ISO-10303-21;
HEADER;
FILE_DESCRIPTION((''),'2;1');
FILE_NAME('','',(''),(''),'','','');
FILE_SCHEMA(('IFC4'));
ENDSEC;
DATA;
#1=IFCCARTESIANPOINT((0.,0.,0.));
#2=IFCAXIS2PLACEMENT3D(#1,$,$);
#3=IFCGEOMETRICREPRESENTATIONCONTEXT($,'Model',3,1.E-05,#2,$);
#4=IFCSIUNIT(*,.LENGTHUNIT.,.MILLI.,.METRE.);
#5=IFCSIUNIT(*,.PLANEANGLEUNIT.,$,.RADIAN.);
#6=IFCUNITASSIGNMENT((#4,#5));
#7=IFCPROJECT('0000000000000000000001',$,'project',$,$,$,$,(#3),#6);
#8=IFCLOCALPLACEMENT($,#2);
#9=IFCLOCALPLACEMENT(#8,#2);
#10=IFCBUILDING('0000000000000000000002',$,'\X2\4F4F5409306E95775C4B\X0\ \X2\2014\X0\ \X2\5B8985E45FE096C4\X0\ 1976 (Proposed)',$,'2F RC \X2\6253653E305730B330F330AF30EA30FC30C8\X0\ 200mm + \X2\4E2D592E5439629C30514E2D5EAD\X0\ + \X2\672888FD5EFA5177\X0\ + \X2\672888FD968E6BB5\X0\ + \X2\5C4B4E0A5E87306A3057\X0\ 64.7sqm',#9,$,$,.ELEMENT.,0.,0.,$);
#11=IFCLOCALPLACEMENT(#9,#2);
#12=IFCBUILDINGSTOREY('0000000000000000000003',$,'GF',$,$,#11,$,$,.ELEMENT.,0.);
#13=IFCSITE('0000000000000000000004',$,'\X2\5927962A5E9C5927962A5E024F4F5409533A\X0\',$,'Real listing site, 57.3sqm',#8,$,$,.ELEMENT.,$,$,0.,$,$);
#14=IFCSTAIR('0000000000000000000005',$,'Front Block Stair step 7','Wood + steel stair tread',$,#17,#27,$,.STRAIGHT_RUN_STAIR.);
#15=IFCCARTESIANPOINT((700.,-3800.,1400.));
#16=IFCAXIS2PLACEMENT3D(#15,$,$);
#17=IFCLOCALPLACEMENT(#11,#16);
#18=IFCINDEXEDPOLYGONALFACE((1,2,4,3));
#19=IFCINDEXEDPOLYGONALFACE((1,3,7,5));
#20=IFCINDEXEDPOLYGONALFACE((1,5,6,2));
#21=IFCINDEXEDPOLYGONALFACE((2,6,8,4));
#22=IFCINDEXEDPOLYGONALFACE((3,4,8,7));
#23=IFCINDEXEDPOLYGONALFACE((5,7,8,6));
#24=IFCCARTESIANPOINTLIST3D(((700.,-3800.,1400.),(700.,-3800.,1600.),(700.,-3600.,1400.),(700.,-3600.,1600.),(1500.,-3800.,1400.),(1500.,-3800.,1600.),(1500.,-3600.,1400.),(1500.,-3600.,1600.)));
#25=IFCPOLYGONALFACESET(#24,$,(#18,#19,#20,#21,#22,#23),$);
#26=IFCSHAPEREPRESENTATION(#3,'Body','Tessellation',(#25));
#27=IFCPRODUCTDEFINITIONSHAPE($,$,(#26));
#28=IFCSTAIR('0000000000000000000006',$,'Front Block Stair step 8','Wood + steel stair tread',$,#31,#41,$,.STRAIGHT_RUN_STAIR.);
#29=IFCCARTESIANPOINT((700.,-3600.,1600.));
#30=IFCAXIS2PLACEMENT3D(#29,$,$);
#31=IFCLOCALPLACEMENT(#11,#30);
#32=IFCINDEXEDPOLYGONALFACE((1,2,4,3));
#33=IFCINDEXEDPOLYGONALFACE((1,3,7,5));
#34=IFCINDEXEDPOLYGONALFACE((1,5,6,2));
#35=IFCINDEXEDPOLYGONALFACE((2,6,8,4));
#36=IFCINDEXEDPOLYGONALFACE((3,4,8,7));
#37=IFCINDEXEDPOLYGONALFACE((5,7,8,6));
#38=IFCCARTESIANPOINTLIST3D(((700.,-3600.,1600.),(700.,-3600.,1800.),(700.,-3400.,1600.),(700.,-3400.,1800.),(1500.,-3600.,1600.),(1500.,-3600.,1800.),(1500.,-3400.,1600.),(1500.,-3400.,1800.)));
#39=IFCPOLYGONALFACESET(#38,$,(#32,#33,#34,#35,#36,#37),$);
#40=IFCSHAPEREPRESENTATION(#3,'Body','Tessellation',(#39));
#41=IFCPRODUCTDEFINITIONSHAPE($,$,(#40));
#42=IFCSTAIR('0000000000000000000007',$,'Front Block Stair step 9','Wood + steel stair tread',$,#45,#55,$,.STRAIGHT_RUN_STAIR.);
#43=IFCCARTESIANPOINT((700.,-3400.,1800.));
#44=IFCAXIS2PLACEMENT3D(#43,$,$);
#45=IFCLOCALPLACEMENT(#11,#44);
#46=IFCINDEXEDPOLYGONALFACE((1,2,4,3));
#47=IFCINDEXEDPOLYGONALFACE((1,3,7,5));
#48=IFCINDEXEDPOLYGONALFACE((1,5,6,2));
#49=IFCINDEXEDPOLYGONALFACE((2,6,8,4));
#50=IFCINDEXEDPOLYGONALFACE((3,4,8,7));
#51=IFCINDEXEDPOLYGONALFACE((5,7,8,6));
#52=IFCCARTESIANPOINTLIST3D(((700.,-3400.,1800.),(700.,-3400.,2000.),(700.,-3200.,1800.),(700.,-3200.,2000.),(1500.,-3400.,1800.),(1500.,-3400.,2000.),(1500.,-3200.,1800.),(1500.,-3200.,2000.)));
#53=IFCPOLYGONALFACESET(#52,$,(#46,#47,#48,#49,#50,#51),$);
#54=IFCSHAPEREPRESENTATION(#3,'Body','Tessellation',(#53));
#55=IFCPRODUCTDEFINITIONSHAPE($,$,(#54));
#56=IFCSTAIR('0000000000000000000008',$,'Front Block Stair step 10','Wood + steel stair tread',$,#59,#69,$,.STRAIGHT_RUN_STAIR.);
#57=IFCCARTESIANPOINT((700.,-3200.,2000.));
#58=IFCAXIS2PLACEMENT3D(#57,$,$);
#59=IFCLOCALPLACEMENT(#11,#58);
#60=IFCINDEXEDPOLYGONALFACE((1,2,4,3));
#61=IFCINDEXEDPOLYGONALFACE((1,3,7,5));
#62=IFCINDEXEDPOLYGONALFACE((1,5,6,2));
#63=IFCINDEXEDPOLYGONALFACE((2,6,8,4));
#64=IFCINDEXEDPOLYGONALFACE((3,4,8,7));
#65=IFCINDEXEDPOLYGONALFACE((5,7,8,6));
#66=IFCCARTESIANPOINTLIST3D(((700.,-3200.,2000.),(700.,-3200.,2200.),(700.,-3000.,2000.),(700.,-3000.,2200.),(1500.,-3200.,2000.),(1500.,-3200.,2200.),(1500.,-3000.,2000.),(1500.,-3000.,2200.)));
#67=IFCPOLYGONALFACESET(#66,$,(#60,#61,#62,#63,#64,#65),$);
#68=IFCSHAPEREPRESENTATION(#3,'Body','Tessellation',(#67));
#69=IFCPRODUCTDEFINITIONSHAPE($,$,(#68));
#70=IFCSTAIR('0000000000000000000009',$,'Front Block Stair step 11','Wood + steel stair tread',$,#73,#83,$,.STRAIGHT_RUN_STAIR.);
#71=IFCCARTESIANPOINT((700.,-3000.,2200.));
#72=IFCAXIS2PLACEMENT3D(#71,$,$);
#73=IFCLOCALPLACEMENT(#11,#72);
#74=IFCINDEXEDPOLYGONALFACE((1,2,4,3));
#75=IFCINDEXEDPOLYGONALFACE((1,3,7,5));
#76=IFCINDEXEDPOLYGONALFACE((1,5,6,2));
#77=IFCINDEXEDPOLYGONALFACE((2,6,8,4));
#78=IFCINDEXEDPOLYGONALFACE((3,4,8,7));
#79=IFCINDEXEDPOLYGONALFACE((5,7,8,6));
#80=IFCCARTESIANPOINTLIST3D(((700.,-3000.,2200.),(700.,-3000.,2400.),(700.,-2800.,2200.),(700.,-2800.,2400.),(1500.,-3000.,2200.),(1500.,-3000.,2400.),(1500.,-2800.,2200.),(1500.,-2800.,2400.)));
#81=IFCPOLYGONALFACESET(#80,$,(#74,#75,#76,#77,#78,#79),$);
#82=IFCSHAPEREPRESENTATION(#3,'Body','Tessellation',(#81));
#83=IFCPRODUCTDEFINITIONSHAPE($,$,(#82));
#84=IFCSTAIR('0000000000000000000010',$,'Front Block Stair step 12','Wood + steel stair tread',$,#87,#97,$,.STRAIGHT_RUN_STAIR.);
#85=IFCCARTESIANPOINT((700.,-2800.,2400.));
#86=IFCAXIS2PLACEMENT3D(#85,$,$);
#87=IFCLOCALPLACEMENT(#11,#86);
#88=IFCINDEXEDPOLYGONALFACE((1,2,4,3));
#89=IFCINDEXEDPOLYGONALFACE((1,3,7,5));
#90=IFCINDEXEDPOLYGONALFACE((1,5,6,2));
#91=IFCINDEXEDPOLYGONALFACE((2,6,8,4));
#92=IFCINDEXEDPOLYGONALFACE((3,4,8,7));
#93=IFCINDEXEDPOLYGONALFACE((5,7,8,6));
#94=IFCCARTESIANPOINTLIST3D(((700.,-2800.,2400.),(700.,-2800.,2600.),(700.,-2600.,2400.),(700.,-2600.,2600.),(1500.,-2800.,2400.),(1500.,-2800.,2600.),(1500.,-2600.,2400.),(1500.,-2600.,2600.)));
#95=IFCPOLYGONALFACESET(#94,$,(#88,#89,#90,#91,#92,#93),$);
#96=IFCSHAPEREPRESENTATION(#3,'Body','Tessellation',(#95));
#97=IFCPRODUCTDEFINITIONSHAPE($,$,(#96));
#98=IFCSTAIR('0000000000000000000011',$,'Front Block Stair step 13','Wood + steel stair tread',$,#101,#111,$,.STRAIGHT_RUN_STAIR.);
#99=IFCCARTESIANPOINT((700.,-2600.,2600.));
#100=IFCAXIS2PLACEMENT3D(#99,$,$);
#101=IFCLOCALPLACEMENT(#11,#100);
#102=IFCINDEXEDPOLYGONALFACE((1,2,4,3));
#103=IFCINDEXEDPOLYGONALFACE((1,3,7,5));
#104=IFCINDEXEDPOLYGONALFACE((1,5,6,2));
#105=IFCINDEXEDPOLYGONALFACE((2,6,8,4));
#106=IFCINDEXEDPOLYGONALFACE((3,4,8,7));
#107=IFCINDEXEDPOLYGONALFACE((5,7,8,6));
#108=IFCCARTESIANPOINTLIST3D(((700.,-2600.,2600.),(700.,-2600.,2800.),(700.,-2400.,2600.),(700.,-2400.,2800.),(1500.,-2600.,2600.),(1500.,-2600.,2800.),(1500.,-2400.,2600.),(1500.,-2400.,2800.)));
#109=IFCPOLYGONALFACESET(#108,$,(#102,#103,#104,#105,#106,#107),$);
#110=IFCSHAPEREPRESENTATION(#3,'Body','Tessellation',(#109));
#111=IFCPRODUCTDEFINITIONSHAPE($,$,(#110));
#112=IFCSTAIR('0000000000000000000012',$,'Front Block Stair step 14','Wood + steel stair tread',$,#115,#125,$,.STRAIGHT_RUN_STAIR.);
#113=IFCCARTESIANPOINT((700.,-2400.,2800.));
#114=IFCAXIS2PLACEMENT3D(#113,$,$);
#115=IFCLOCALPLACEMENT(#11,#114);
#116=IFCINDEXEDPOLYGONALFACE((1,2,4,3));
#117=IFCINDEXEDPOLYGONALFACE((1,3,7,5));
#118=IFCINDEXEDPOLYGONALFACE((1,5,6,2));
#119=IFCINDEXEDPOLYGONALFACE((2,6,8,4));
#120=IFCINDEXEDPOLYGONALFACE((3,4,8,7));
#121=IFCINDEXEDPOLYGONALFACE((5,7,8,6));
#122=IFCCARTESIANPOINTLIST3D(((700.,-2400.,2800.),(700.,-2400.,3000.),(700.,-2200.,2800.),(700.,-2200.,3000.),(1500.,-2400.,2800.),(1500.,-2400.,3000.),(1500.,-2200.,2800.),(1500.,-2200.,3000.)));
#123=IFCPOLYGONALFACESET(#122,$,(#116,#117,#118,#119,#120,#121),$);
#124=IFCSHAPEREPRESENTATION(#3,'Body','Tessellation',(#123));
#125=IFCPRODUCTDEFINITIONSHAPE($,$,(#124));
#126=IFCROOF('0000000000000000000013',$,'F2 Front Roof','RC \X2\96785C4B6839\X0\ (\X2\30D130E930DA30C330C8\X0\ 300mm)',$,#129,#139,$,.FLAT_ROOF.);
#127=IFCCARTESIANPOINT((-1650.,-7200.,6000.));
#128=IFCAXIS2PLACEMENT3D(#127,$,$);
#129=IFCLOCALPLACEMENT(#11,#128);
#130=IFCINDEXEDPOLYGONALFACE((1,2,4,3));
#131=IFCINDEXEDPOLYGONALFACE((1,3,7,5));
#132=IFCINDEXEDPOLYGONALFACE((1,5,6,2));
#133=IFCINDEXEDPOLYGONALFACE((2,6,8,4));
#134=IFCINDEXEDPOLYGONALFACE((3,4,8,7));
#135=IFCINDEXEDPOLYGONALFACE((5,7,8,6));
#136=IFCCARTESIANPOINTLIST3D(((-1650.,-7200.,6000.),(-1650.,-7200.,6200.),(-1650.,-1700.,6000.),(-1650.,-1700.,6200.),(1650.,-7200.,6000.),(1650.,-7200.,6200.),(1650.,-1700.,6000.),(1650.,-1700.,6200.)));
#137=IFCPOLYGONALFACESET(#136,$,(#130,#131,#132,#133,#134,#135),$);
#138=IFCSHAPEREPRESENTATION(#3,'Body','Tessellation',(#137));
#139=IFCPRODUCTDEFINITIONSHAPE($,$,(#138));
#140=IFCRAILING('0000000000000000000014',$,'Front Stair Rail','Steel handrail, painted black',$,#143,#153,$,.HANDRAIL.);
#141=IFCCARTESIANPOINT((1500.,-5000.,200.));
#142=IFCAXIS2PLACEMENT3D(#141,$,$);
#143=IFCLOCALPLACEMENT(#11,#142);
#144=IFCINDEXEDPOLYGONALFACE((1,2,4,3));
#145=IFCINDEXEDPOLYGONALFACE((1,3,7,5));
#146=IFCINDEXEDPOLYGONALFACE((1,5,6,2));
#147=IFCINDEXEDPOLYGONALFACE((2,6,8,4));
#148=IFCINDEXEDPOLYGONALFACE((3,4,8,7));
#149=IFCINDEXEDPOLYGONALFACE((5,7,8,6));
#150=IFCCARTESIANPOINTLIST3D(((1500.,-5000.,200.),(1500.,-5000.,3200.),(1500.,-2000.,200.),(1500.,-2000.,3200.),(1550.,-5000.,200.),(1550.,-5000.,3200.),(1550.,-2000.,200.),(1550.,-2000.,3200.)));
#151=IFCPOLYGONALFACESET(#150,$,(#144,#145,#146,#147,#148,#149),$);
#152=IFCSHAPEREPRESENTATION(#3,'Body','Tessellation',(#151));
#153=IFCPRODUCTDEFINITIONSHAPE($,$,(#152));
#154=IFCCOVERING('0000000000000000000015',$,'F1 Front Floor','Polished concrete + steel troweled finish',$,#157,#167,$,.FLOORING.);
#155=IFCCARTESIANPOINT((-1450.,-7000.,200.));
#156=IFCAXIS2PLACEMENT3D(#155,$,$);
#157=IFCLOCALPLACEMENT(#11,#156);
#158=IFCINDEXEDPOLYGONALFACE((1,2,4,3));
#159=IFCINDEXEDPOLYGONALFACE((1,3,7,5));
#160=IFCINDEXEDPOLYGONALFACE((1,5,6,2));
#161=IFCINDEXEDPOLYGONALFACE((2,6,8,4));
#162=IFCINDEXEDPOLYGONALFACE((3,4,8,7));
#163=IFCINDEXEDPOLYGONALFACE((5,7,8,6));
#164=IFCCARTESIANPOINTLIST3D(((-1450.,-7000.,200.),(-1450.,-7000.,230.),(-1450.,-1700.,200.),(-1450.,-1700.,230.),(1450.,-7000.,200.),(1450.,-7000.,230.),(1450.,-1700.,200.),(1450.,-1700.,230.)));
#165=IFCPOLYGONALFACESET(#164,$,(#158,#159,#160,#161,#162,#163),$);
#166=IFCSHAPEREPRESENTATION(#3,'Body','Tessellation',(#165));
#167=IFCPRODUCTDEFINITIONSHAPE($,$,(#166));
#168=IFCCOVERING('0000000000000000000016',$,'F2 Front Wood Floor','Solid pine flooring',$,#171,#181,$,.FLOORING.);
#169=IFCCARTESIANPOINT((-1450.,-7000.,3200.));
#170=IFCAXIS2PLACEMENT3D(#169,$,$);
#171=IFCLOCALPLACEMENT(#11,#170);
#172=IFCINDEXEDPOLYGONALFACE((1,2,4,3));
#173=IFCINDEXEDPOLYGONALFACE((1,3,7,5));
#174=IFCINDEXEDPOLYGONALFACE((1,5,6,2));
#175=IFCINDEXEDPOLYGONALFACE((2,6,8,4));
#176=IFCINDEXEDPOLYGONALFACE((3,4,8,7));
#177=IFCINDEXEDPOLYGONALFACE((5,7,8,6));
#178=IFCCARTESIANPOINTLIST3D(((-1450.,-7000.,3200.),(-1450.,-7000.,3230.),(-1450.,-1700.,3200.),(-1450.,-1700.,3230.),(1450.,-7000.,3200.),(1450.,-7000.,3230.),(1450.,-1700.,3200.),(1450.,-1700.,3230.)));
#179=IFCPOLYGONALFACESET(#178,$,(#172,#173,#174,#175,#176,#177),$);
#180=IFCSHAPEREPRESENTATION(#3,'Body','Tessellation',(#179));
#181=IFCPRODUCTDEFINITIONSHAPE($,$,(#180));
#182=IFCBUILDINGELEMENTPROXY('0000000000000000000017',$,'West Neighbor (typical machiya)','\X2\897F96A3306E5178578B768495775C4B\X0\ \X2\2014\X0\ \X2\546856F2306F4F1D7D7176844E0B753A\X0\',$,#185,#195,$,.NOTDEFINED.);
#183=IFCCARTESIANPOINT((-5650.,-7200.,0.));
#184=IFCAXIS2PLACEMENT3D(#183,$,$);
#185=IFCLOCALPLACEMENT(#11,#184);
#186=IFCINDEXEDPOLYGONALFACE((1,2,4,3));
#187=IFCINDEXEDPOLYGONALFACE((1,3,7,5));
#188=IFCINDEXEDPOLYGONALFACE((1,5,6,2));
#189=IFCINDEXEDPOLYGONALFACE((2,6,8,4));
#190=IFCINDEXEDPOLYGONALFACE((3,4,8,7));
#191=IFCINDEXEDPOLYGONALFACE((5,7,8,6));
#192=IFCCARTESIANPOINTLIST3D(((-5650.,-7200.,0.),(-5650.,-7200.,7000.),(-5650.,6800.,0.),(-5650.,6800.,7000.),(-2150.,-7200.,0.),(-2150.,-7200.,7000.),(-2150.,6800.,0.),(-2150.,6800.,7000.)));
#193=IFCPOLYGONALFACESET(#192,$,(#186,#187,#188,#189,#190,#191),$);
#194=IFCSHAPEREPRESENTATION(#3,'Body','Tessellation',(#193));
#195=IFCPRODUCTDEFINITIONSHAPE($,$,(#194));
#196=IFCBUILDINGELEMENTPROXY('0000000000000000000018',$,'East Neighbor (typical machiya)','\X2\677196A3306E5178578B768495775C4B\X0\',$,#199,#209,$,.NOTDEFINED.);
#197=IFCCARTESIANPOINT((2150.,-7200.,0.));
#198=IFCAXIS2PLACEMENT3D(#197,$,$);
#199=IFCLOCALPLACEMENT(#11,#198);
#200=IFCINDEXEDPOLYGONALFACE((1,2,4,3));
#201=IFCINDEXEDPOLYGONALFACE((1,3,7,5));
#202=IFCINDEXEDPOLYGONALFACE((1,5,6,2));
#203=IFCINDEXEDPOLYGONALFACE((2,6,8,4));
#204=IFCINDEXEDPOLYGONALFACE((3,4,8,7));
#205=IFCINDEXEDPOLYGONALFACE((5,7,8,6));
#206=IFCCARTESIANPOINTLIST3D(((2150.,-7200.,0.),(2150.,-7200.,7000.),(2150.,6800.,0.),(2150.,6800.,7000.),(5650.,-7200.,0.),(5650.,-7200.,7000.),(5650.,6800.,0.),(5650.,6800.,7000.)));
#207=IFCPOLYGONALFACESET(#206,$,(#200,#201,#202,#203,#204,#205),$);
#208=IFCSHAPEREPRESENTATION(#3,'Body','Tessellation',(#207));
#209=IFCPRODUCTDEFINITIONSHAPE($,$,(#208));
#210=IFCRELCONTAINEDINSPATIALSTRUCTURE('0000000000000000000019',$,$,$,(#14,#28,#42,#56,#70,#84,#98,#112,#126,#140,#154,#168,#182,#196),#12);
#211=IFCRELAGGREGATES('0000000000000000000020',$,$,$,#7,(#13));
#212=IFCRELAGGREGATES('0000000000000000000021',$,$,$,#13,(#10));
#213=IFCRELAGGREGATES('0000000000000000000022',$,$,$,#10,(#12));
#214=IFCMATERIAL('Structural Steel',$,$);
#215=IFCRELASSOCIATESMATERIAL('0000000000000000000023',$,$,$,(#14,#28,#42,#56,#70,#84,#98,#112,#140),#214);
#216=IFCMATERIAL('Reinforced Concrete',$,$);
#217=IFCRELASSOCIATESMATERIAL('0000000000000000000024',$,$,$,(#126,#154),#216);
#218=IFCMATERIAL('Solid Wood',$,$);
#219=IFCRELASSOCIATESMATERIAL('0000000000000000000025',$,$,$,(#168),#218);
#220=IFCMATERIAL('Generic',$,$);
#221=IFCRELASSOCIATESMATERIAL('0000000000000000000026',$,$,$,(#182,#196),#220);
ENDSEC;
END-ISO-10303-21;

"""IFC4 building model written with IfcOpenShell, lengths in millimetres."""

from ifc_helpers import new_model, si_unit, frame, frame_2d, origin, place, context, project, spatial, rectangle, extrude, material, element, save


model = new_model("IFC4")

# Units and contexts
model_context = context("Model", 3, precision=1e-05, world=origin())
ifc_project = project(units=[si_unit("LENGTHUNIT", "METRE", prefix="MILLI"), si_unit("PLANEANGLEUNIT", "RADIAN")], contexts=[model_context])

# Site, building, storey
site_placement = place(None, origin())
site = spatial("IfcSite", under=ifc_project, at=site_placement, Name="大阪府大阪市住吉区", ObjectType="Real listing site, 57.3sqm", CompositionType="ELEMENT", RefElevation=0.0)
building_placement = place(site_placement, origin())
building = spatial("IfcBuilding", under=site, at=building_placement, Name="住吉の長屋 — 安藤忠雄 1976 (Proposed)", ObjectType="2F RC 打放しコンクリート 200mm + 中央吹抜け中庭 + 木製建具 + 木製階段 + 屋上庇なし 64.7sqm", CompositionType="ELEMENT", ElevationOfRefHeight=0.0, ElevationOfTerrain=0.0)
storey_placement = place(building_placement, origin())
storey = spatial("IfcBuildingStorey", under=building, at=storey_placement, Name="GF", CompositionType="ELEMENT", Elevation=0.0)

# Shared definitions
ifc_material_1 = material(Name="Reinforced Concrete")
ifc_material_2 = material(Name="Generic")

# Shared definitions
ifc_material_3 = material(Name="Solid Wood")

# Stairs
ifc_material_4 = material(Name="Structural Steel")
stair_1_placement = place(storey_placement, frame((700.0, -3800.0, 1400.0)))
element("IfcStair", 1, at=stair_1_placement, inside=storey, material=ifc_material_4, Name="Front Block Stair step 7", Description="Wood + steel stair tread", PredefinedType="STRAIGHT_RUN_STAIR", context=model_context, shape_type="SweptSolid", body=[
    extrude(rectangle(XDim=800.0, YDim=200.0, at=frame_2d((400.0, 100.0))), frame((700.0, -3800.0, 1400.0)), (0.0, 0.0, 1.0), 200.0),
])
stair_2_placement = place(storey_placement, frame((700.0, -3600.0, 1600.0)))
element("IfcStair", 2, at=stair_2_placement, inside=storey, material=ifc_material_4, Name="Front Block Stair step 8", Description="Wood + steel stair tread", PredefinedType="STRAIGHT_RUN_STAIR", context=model_context, shape_type="SweptSolid", body=[
    extrude(rectangle(XDim=800.0, YDim=200.0, at=frame_2d((400.0, 100.0))), frame((700.0, -3600.0, 1600.0)), (0.0, 0.0, 1.0), 200.0),
])
stair_3_placement = place(storey_placement, frame((700.0, -3400.0, 1800.0)))
element("IfcStair", 3, at=stair_3_placement, inside=storey, material=ifc_material_4, Name="Front Block Stair step 9", Description="Wood + steel stair tread", PredefinedType="STRAIGHT_RUN_STAIR", context=model_context, shape_type="SweptSolid", body=[
    extrude(rectangle(XDim=800.0, YDim=200.0, at=frame_2d((400.0, 100.0))), frame((700.0, -3400.0, 1800.0)), (0.0, 0.0, 1.0), 200.0),
])
stair_4_placement = place(storey_placement, frame((700.0, -3200.0, 2000.0)))
element("IfcStair", 4, at=stair_4_placement, inside=storey, material=ifc_material_4, Name="Front Block Stair step 10", Description="Wood + steel stair tread", PredefinedType="STRAIGHT_RUN_STAIR", context=model_context, shape_type="SweptSolid", body=[
    extrude(rectangle(XDim=800.0, YDim=200.0, at=frame_2d((400.0, 100.0))), frame((700.0, -3200.0, 2000.0)), (0.0, 0.0, 1.0), 200.0),
])
stair_5_placement = place(storey_placement, frame((700.0, -3000.0, 2200.0)))
element("IfcStair", 5, at=stair_5_placement, inside=storey, material=ifc_material_4, Name="Front Block Stair step 11", Description="Wood + steel stair tread", PredefinedType="STRAIGHT_RUN_STAIR", context=model_context, shape_type="SweptSolid", body=[
    extrude(rectangle(XDim=800.0, YDim=200.0, at=frame_2d((400.0, 100.0))), frame((700.0, -3000.0, 2200.0)), (0.0, 0.0, 1.0), 200.0),
])
stair_6_placement = place(storey_placement, frame((700.0, -2800.0, 2400.0)))
element("IfcStair", 6, at=stair_6_placement, inside=storey, material=ifc_material_4, Name="Front Block Stair step 12", Description="Wood + steel stair tread", PredefinedType="STRAIGHT_RUN_STAIR", context=model_context, shape_type="SweptSolid", body=[
    extrude(rectangle(XDim=800.0, YDim=200.0, at=frame_2d((400.0, 100.0))), frame((700.0, -2800.0, 2400.0)), (0.0, 0.0, 1.0), 200.0),
])
stair_7_placement = place(storey_placement, frame((700.0, -2600.0, 2600.0)))
element("IfcStair", 7, at=stair_7_placement, inside=storey, material=ifc_material_4, Name="Front Block Stair step 13", Description="Wood + steel stair tread", PredefinedType="STRAIGHT_RUN_STAIR", context=model_context, shape_type="SweptSolid", body=[
    extrude(rectangle(XDim=800.0, YDim=200.0, at=frame_2d((400.0, 100.0))), frame((700.0, -2600.0, 2600.0)), (0.0, 0.0, 1.0), 200.0),
])
stair_8_placement = place(storey_placement, frame((700.0, -2400.0, 2800.0)))
element("IfcStair", 8, at=stair_8_placement, inside=storey, material=ifc_material_4, Name="Front Block Stair step 14", Description="Wood + steel stair tread", PredefinedType="STRAIGHT_RUN_STAIR", context=model_context, shape_type="SweptSolid", body=[
    extrude(rectangle(XDim=800.0, YDim=200.0, at=frame_2d((400.0, 100.0))), frame((700.0, -2400.0, 2800.0)), (0.0, 0.0, 1.0), 200.0),
])

# Roof
roof_placement = place(storey_placement, frame((-1650.0, -7200.0, 6000.0)))
element("IfcRoof", 9, at=roof_placement, inside=storey, material=ifc_material_1, Name="F2 Front Roof", Description="RC 陸屋根 (パラペット 300mm)", PredefinedType="FLAT_ROOF", context=model_context, shape_type="SweptSolid", body=[
    extrude(rectangle(XDim=3300.0, YDim=5500.0, at=frame_2d((1650.0, 2750.0))), frame((-1650.0, -7200.0, 6000.0)), (0.0, 0.0, 1.0), 200.0),
])

# Railing
railing_placement = place(storey_placement, frame((1500.0, -5000.0, 200.0)))
element("IfcRailing", 10, at=railing_placement, inside=storey, material=ifc_material_4, Name="Front Stair Rail", Description="Steel handrail, painted black", PredefinedType="HANDRAIL", context=model_context, shape_type="SweptSolid", body=[
    extrude(rectangle(XDim=50.0, YDim=3000.0, at=frame_2d((25.0, 1500.0))), frame((1500.0, -5000.0, 200.0)), (0.0, 0.0, 1.0), 3000.0),
])

# Coverings
covering_1_placement = place(storey_placement, frame((-1450.0, -7000.0, 200.0)))
element("IfcCovering", 11, at=covering_1_placement, inside=storey, material=ifc_material_1, Name="F1 Front Floor", Description="Polished concrete + steel troweled finish", PredefinedType="FLOORING", context=model_context, shape_type="SweptSolid", body=[
    extrude(rectangle(XDim=2900.0, YDim=5300.0, at=frame_2d((1450.0, 2650.0))), frame((-1450.0, -7000.0, 200.0)), (0.0, 0.0, 1.0), 30.0),
])
covering_2_placement = place(storey_placement, frame((-1450.0, -7000.0, 3200.0)))
element("IfcCovering", 12, at=covering_2_placement, inside=storey, material=ifc_material_3, Name="F2 Front Wood Floor", Description="Solid pine flooring", PredefinedType="FLOORING", context=model_context, shape_type="SweptSolid", body=[
    extrude(rectangle(XDim=2900.0, YDim=5300.0, at=frame_2d((1450.0, 2650.0))), frame((-1450.0, -7000.0, 3200.0)), (0.0, 0.0, 1.0), 30.0),
])

# Building element proxies
proxy_1_placement = place(storey_placement, frame((-5650.0, -7200.0, 0.0)))
element("IfcBuildingElementProxy", 13, at=proxy_1_placement, inside=storey, material=ifc_material_2, Name="West Neighbor (typical machiya)", Description="西隣の典型的長屋 — 周囲は伝統的下町", PredefinedType="NOTDEFINED", context=model_context, shape_type="SweptSolid", body=[
    extrude(rectangle(XDim=3500.0, YDim=14000.0, at=frame_2d((1750.0, 7000.0))), frame((-5650.0, -7200.0, 0.0)), (0.0, 0.0, 1.0), 7000.0),
])
proxy_2_placement = place(storey_placement, frame((2150.0, -7200.0, 0.0)))
element("IfcBuildingElementProxy", 14, at=proxy_2_placement, inside=storey, material=ifc_material_2, Name="East Neighbor (typical machiya)", Description="東隣の典型的長屋", PredefinedType="NOTDEFINED", context=model_context, shape_type="SweptSolid", body=[
    extrude(rectangle(XDim=3500.0, YDim=14000.0, at=frame_2d((1750.0, 7000.0))), frame((2150.0, -7200.0, 0.0)), (0.0, 0.0, 1.0), 7000.0),
])

save(model, "model.ifc")
